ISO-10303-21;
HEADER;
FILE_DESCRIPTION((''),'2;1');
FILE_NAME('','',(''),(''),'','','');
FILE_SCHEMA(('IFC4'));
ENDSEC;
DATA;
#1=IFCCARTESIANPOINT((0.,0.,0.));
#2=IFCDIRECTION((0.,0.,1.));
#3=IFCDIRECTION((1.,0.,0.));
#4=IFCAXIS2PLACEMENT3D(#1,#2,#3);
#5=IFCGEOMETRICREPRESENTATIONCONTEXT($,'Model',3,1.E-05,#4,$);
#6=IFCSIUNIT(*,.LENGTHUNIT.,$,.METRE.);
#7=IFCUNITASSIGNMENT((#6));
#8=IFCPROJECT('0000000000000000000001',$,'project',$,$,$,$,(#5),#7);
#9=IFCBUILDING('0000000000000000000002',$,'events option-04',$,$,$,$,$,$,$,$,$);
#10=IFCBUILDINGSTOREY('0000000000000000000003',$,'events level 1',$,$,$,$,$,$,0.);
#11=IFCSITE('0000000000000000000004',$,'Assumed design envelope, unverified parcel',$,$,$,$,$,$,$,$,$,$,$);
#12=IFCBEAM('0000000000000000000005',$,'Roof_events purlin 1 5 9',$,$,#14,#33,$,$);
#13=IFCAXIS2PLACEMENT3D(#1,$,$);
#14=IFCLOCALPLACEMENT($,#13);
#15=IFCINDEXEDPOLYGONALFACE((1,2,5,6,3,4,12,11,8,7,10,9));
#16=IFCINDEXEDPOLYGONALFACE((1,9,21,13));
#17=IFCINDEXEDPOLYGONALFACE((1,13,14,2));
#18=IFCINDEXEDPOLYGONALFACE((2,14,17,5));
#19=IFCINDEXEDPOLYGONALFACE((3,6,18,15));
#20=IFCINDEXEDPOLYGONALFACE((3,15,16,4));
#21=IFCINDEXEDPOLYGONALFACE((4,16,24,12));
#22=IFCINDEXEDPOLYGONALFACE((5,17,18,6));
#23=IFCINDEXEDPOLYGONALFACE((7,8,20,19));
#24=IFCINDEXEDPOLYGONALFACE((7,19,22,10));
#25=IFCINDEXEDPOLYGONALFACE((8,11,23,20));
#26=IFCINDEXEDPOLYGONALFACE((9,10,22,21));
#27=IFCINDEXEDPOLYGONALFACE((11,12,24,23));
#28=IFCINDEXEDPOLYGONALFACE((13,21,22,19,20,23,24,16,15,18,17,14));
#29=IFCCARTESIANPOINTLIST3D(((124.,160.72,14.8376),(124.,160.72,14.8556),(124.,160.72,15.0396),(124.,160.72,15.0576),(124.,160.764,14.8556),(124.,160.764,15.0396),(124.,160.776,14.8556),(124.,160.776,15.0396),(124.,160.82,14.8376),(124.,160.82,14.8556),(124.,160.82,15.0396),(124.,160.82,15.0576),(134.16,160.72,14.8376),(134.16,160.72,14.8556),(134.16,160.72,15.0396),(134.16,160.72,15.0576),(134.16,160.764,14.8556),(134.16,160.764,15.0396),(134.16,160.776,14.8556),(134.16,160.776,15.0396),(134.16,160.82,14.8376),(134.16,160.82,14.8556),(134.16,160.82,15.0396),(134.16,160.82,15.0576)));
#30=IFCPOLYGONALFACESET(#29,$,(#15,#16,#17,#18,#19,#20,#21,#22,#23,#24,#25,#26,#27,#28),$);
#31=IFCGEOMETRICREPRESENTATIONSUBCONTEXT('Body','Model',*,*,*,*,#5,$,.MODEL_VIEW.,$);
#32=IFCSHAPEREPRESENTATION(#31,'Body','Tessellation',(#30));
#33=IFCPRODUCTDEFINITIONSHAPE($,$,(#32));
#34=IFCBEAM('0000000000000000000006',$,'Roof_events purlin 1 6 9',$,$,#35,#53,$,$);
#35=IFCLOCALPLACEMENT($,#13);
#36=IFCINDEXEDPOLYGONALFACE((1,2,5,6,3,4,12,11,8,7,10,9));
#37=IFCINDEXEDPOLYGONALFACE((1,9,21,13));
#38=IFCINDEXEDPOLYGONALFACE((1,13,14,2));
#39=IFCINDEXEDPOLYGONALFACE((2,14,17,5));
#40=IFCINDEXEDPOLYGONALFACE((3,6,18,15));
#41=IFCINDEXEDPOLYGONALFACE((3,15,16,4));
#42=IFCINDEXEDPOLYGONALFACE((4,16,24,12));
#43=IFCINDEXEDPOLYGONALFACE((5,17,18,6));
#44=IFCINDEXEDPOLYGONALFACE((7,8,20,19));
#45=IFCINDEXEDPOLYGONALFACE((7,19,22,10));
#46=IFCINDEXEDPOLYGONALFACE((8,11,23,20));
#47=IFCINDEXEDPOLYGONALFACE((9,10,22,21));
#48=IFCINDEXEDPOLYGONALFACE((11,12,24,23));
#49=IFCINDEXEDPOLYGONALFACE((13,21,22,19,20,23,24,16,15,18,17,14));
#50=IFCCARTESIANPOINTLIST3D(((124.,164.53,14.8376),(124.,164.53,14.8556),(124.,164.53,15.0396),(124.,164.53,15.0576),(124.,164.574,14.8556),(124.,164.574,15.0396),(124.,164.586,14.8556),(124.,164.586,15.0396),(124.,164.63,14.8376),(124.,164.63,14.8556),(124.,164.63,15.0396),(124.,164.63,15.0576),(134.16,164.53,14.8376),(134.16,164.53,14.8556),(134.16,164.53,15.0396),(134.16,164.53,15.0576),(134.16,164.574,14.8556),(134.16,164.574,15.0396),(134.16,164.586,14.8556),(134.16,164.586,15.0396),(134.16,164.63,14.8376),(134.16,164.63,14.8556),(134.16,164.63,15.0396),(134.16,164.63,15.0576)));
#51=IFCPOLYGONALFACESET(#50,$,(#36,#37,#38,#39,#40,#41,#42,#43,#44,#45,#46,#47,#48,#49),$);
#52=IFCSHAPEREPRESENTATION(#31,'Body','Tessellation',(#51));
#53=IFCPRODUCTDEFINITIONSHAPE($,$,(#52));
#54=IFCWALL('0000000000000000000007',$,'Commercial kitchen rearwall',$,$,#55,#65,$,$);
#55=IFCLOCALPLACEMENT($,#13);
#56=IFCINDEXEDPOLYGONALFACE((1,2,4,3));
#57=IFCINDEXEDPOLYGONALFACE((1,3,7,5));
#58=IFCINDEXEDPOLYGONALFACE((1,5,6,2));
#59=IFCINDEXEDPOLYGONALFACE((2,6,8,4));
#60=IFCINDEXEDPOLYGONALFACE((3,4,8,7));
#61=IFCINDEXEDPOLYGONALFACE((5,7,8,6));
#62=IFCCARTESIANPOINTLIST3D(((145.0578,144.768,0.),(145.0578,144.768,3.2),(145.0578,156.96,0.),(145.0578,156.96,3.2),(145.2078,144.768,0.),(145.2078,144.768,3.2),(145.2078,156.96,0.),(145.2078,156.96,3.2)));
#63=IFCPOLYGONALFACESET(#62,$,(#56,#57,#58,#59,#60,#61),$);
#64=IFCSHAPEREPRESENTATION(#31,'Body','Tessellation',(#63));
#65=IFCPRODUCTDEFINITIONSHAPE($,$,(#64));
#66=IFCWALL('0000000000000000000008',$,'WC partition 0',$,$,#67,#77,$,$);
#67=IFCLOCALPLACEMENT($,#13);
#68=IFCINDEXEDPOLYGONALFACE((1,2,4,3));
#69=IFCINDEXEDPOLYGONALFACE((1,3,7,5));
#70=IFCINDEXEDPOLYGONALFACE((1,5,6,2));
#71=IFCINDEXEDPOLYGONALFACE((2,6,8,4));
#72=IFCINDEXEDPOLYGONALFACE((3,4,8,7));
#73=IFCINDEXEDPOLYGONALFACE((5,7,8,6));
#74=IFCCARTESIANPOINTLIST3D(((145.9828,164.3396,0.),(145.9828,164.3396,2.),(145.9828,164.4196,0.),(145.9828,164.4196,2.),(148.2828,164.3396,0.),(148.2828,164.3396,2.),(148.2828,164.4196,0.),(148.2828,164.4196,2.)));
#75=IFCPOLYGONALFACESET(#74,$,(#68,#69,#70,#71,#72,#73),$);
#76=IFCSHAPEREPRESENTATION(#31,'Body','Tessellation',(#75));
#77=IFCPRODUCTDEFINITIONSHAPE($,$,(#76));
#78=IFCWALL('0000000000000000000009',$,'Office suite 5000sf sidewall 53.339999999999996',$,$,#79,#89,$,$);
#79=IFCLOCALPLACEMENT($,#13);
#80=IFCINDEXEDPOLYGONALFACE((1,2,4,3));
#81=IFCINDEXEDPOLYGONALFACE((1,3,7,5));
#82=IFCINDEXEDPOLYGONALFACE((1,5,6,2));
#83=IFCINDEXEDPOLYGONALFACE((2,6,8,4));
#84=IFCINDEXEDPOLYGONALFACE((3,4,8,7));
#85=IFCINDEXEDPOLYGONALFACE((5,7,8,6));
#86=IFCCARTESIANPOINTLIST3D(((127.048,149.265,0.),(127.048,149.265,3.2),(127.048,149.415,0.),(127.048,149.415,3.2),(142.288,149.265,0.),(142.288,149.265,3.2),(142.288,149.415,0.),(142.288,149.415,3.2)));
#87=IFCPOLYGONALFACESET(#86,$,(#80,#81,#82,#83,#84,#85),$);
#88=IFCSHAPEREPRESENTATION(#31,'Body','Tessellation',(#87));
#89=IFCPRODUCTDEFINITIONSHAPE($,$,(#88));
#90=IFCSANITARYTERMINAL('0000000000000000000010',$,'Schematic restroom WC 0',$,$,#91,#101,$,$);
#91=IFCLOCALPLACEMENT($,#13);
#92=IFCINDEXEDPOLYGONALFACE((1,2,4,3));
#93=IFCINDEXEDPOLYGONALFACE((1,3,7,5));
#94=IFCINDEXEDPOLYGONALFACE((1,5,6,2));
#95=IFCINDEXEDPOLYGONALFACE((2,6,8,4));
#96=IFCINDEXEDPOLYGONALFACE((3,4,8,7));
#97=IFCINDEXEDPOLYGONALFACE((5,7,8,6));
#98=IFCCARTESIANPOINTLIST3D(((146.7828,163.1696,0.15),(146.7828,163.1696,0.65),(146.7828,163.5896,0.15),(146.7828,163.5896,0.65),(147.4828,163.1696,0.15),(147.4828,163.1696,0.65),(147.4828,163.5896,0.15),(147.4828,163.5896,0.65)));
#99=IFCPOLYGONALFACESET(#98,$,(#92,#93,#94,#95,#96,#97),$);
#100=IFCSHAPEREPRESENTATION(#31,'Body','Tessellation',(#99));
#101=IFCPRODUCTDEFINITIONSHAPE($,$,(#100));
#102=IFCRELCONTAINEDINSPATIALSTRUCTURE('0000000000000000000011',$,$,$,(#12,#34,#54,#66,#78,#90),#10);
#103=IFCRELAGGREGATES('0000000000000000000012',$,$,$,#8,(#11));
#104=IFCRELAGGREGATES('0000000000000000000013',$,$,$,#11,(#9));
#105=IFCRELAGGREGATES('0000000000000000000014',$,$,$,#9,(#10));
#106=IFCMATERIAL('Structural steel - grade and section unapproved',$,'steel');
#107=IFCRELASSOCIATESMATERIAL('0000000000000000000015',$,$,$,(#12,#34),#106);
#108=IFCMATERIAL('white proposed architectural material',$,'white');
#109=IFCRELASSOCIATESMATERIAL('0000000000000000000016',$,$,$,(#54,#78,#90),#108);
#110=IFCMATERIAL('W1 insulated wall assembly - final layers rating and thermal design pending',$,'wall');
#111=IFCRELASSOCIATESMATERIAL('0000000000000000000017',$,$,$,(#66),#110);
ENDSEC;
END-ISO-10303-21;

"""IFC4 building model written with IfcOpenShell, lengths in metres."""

from ifc_helpers import new_model, si_unit, frame, origin_with_axes, place, context, subcontext, project, spatial, rectangle, i_section, extrude, material, element, save


model = new_model("IFC4")

# Units and contexts
model_context = context("Model", 3, precision=1e-05, world=origin_with_axes())
body_context = subcontext(model_context, "Body", "Model", "MODEL_VIEW")
ifc_project = project(units=[si_unit("LENGTHUNIT", "METRE")], contexts=[model_context])

# Site, building, storey
site = spatial("IfcSite", under=ifc_project, Name="Assumed design envelope, unverified parcel")
building = spatial("IfcBuilding", under=site, Name="events option-04")
storey = spatial("IfcBuildingStorey", under=building, Name="events level 1", Elevation=0.0)

# Shared definitions
ifc_material_1 = material(Name="Structural steel - grade and section unapproved", Category="steel")

# Beams
for number, where, z_axis, x_axis, name in (
    (1, (134.16, 160.77, 14.9476), (-1.0, 0.0, 0.0), (0.0, -1.0, 0.0), "Roof_events purlin 1 5 9"),
    (2, (134.16, 164.58, 14.9476), (-1.0, 0.0, 0.0), (0.0, -1.0, 0.0), "Roof_events purlin 1 6 9"),
):
    element("IfcBeam", number, at=place(None, frame(where, z_axis=z_axis, x_axis=x_axis)), inside=storey, material=ifc_material_1, Name=name, context=body_context, shape_type="SweptSolid", body=[
        extrude(i_section(OverallWidth=0.1, OverallDepth=0.22, WebThickness=0.012, FlangeThickness=0.018, FilletRadius=0.0), origin_with_axes(), (0.0, 0.0, 1.0), 10.16),
    ])

# Walls
ifc_material_2 = material(Name="white proposed architectural material", Category="white")
wall_1_placement = place(None, frame((145.1328, 150.864, 0.0), z_axis=(0.0, 0.0, 1.0), x_axis=(0.0, 1.0, 0.0)))
element("IfcWall", 3, at=wall_1_placement, inside=storey, material=ifc_material_2, Name="Commercial kitchen rearwall", context=body_context, shape_type="SweptSolid", body=[
    extrude(rectangle(XDim=12.192, YDim=0.15), origin_with_axes(), (0.0, 0.0, 1.0), 3.2),
])
ifc_material_3 = material(Name="W1 insulated wall assembly - final layers rating and thermal design pending", Category="wall")
wall_2_placement = place(None, frame((147.1328, 164.3796, 0.0), z_axis=(0.0, 0.0, 1.0), x_axis=(0.0, 1.0, 0.0)))
element("IfcWall", 4, at=wall_2_placement, inside=storey, material=ifc_material_3, Name="WC partition 0", context=body_context, shape_type="SweptSolid", body=[
    extrude(rectangle(XDim=0.08, YDim=2.3), origin_with_axes(), (0.0, 0.0, 1.0), 2.0),
])
wall_3_placement = place(None, frame((134.668, 149.34, 0.0), z_axis=(0.0, 0.0, 1.0), x_axis=(0.0, 1.0, 0.0)))
element("IfcWall", 5, at=wall_3_placement, inside=storey, material=ifc_material_2, Name="Office suite 5000sf sidewall 53.339999999999996", context=body_context, shape_type="SweptSolid", body=[
    extrude(rectangle(XDim=0.15, YDim=15.24), origin_with_axes(), (0.0, 0.0, 1.0), 3.2),
])

# Sanitary terminal
sanitary_terminal_placement = place(None, frame((147.1328, 163.3796, 0.15), z_axis=(0.0, 0.0, 1.0), x_axis=(0.0, 1.0, 0.0)))
element("IfcSanitaryTerminal", 6, at=sanitary_terminal_placement, inside=storey, material=ifc_material_2, Name="Schematic restroom WC 0", context=body_context, shape_type="SweptSolid", body=[
    extrude(rectangle(XDim=0.42, YDim=0.7), origin_with_axes(), (0.0, 0.0, 1.0), 0.5),
])

save(model, "model.ifc")
